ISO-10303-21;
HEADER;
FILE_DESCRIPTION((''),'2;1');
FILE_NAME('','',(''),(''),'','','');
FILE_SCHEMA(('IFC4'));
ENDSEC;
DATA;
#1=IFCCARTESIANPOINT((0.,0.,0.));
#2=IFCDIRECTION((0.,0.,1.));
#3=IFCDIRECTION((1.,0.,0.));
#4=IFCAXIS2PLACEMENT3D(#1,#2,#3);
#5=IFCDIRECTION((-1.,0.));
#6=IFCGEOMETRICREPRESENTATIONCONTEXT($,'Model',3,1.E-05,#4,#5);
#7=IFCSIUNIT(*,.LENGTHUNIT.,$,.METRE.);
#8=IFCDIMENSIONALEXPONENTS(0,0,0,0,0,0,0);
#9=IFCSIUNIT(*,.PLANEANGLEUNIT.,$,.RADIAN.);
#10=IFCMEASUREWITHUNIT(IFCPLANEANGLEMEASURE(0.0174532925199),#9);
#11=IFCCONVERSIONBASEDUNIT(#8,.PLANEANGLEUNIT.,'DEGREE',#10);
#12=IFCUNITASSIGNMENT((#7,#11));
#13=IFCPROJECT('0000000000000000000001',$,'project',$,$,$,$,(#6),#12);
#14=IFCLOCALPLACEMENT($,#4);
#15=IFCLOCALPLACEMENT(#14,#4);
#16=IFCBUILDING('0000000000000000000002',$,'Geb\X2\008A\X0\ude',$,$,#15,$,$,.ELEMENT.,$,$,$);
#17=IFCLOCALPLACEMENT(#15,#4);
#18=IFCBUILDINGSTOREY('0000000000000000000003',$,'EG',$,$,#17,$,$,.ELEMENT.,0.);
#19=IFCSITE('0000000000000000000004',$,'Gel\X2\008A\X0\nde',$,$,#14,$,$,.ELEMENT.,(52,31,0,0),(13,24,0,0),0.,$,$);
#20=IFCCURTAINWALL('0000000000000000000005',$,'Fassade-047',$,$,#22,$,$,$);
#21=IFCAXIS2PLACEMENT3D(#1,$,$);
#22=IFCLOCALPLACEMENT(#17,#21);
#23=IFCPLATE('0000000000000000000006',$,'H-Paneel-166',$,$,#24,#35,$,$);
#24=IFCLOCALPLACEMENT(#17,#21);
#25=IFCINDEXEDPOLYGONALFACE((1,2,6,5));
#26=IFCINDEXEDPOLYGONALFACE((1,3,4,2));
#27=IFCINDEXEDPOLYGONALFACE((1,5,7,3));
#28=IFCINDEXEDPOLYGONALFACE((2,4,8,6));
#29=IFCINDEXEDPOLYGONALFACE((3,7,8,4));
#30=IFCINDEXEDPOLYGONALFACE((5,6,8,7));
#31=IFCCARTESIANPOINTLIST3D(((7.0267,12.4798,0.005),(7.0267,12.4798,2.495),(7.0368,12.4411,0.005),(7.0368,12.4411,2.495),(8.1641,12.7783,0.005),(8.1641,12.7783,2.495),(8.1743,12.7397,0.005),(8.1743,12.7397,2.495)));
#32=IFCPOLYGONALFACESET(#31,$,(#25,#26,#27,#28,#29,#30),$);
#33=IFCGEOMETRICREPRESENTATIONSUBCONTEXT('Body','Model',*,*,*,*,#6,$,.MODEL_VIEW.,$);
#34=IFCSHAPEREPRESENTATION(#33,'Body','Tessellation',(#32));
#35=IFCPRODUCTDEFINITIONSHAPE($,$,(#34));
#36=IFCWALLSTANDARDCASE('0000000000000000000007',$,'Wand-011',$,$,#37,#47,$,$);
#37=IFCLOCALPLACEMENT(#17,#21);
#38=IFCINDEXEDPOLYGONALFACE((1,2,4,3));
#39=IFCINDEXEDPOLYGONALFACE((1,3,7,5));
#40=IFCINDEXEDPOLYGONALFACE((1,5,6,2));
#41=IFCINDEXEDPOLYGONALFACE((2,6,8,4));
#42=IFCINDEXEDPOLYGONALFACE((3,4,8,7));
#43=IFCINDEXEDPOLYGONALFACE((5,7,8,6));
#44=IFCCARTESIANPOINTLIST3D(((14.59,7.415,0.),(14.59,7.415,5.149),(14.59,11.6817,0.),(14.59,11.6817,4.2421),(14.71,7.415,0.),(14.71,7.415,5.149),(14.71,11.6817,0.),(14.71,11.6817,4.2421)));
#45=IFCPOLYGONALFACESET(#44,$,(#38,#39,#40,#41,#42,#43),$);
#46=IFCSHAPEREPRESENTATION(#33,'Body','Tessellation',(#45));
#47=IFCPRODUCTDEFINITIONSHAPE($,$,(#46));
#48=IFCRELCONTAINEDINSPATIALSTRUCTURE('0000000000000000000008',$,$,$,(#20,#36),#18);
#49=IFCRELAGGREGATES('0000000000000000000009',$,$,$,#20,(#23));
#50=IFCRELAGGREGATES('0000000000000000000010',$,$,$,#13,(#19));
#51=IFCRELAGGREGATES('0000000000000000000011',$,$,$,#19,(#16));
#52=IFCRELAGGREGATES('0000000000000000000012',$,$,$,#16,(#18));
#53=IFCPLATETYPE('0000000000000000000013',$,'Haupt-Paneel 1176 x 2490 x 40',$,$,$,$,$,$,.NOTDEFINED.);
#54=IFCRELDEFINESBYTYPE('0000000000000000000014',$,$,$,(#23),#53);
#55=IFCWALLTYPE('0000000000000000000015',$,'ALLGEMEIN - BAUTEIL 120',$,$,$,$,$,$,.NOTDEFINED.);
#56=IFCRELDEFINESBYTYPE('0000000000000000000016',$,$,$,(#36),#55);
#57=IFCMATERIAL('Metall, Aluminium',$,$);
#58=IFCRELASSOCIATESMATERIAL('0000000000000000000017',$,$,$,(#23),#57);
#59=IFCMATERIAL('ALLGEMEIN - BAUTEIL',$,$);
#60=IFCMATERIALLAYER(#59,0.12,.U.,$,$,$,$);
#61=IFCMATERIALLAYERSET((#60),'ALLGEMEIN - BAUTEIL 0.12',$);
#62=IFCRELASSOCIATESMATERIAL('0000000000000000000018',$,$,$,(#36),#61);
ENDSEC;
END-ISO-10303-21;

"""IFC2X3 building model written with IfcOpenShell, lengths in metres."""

from ifc_helpers import new_model, entity, si_unit, converted_unit, direction, frame, origin_with_axes, place, context, subcontext, project, spatial, polyline, outline, extrude, clip, halfspace, material, layer, layer_set, layer_usage, type_object, element, aggregate, save


model = new_model("IFC2X3")

# Units and contexts
model_context = context("Model", 3, precision=1e-05, world=origin_with_axes(), true_north=direction((-1.0, 0.0)))
body_context = subcontext(model_context, "Body", "Model", "MODEL_VIEW")
ifc_project = project(units=[si_unit("LENGTHUNIT", "METRE"), converted_unit("PLANEANGLEUNIT", "DEGREE", entity("IfcPlaneAngleMeasure", 0.0174532925199), si_unit("PLANEANGLEUNIT", "RADIAN"), dimensions=[0, 0, 0, 0, 0, 0, 0])], contexts=[model_context])

# Site, building, storey
site_placement = place(None, origin_with_axes())
site = spatial("IfcSite", under=ifc_project, at=site_placement, Name="Gel\u008ande", CompositionType="ELEMENT", RefLatitude=(52, 31, 0, 0), RefLongitude=(13, 24, 0, 0), RefElevation=0.0)
building_placement = place(site_placement, origin_with_axes())
building = spatial("IfcBuilding", under=site, at=building_placement, Name="Geb\u008aude", CompositionType="ELEMENT")
storey_placement = place(building_placement, origin_with_axes())
storey = spatial("IfcBuildingStorey", under=building, at=storey_placement, Name="EG", CompositionType="ELEMENT", Elevation=0.0)

# Curtain wall
curtain_wall_1_placement = place(storey_placement, frame((7.6056, 12.5904, 0.0), z_axis=(0.0, 0.0, 1.0), x_axis=(1.0, 0.0, 0.0)))
curtain_wall_1 = element("IfcCurtainWall", 1, at=curtain_wall_1_placement, inside=storey, Name="Fassade-047")
ifc_material_1 = material(Name="Metall, Aluminium")

# Shared definitions
ifc_material_2 = material(Name="ALLGEMEIN - BAUTEIL")

# Plate
plate_type_1 = type_object("IfcPlateType", Name="Haupt-Paneel 1176 x 2490 x 40", PredefinedType="NOTDEFINED")
plate_1_placement = place(curtain_wall_1_placement, frame((0.0, 0.0, 1.25), z_axis=(0.0, 0.0, 1.0), x_axis=(0.967233, 0.25389, 0.0)))
plate_1 = element("IfcPlate", 2, at=plate_1_placement, type_object=plate_type_1, material=ifc_material_1, Name="H-Paneel-166", context=body_context, shape_type="SweptSolid", body=[
    extrude(outline(polyline([(0.005, 0.005), (1.181, 0.005), (1.181, 2.495), (0.005, 2.495), (0.005, 0.005)])), frame((0.593, 0.0, -1.25), z_axis=(0.0, 1.0, 0.0), x_axis=(-1.0, 0.0, 0.0)), (0.0, 0.0, 1.0), 0.04),
])
aggregate(curtain_wall_1, [plate_1])

# Wall
ifc_layer_1 = layer(ifc_material_2, 0.12, ventilated="UNKNOWN")
ifc_layer_set_1 = layer_set([ifc_layer_1], Name="ALLGEMEIN - BAUTEIL 0.12")
ifc_layer_usage_1 = layer_usage(ifc_layer_set_1, "AXIS2", "POSITIVE", 0.0)
wall_type = type_object("IfcWallType", Name="ALLGEMEIN - BAUTEIL 120", PredefinedType="NOTDEFINED")
wall_placement = place(storey_placement, frame((14.59, 11.6817, 0.0), z_axis=(0.0, 0.0, 1.0), x_axis=(0.0, -1.0, 0.0)))
element("IfcWallStandardCase", 3, at=wall_placement, inside=storey, type_object=wall_type, material=ifc_layer_usage_1, Name="Wand-011", context=body_context, shape_type="Clipping", body=[
    clip(extrude(outline(polyline([(0.0, 0.0), (4.2667, 0.0), (4.2667, 0.12), (0.0, 0.12), (0.0, 0.0)])), origin_with_axes(), (0.0, 0.0, 1.0), 7.0), halfspace(frame((-0.8627, 0.0, 4.0587), z_axis=(0.207912, 0.0, -0.978148), x_axis=(0.978148, 0.0, 0.207912)), True)),
])

save(model, "model.ifc")
